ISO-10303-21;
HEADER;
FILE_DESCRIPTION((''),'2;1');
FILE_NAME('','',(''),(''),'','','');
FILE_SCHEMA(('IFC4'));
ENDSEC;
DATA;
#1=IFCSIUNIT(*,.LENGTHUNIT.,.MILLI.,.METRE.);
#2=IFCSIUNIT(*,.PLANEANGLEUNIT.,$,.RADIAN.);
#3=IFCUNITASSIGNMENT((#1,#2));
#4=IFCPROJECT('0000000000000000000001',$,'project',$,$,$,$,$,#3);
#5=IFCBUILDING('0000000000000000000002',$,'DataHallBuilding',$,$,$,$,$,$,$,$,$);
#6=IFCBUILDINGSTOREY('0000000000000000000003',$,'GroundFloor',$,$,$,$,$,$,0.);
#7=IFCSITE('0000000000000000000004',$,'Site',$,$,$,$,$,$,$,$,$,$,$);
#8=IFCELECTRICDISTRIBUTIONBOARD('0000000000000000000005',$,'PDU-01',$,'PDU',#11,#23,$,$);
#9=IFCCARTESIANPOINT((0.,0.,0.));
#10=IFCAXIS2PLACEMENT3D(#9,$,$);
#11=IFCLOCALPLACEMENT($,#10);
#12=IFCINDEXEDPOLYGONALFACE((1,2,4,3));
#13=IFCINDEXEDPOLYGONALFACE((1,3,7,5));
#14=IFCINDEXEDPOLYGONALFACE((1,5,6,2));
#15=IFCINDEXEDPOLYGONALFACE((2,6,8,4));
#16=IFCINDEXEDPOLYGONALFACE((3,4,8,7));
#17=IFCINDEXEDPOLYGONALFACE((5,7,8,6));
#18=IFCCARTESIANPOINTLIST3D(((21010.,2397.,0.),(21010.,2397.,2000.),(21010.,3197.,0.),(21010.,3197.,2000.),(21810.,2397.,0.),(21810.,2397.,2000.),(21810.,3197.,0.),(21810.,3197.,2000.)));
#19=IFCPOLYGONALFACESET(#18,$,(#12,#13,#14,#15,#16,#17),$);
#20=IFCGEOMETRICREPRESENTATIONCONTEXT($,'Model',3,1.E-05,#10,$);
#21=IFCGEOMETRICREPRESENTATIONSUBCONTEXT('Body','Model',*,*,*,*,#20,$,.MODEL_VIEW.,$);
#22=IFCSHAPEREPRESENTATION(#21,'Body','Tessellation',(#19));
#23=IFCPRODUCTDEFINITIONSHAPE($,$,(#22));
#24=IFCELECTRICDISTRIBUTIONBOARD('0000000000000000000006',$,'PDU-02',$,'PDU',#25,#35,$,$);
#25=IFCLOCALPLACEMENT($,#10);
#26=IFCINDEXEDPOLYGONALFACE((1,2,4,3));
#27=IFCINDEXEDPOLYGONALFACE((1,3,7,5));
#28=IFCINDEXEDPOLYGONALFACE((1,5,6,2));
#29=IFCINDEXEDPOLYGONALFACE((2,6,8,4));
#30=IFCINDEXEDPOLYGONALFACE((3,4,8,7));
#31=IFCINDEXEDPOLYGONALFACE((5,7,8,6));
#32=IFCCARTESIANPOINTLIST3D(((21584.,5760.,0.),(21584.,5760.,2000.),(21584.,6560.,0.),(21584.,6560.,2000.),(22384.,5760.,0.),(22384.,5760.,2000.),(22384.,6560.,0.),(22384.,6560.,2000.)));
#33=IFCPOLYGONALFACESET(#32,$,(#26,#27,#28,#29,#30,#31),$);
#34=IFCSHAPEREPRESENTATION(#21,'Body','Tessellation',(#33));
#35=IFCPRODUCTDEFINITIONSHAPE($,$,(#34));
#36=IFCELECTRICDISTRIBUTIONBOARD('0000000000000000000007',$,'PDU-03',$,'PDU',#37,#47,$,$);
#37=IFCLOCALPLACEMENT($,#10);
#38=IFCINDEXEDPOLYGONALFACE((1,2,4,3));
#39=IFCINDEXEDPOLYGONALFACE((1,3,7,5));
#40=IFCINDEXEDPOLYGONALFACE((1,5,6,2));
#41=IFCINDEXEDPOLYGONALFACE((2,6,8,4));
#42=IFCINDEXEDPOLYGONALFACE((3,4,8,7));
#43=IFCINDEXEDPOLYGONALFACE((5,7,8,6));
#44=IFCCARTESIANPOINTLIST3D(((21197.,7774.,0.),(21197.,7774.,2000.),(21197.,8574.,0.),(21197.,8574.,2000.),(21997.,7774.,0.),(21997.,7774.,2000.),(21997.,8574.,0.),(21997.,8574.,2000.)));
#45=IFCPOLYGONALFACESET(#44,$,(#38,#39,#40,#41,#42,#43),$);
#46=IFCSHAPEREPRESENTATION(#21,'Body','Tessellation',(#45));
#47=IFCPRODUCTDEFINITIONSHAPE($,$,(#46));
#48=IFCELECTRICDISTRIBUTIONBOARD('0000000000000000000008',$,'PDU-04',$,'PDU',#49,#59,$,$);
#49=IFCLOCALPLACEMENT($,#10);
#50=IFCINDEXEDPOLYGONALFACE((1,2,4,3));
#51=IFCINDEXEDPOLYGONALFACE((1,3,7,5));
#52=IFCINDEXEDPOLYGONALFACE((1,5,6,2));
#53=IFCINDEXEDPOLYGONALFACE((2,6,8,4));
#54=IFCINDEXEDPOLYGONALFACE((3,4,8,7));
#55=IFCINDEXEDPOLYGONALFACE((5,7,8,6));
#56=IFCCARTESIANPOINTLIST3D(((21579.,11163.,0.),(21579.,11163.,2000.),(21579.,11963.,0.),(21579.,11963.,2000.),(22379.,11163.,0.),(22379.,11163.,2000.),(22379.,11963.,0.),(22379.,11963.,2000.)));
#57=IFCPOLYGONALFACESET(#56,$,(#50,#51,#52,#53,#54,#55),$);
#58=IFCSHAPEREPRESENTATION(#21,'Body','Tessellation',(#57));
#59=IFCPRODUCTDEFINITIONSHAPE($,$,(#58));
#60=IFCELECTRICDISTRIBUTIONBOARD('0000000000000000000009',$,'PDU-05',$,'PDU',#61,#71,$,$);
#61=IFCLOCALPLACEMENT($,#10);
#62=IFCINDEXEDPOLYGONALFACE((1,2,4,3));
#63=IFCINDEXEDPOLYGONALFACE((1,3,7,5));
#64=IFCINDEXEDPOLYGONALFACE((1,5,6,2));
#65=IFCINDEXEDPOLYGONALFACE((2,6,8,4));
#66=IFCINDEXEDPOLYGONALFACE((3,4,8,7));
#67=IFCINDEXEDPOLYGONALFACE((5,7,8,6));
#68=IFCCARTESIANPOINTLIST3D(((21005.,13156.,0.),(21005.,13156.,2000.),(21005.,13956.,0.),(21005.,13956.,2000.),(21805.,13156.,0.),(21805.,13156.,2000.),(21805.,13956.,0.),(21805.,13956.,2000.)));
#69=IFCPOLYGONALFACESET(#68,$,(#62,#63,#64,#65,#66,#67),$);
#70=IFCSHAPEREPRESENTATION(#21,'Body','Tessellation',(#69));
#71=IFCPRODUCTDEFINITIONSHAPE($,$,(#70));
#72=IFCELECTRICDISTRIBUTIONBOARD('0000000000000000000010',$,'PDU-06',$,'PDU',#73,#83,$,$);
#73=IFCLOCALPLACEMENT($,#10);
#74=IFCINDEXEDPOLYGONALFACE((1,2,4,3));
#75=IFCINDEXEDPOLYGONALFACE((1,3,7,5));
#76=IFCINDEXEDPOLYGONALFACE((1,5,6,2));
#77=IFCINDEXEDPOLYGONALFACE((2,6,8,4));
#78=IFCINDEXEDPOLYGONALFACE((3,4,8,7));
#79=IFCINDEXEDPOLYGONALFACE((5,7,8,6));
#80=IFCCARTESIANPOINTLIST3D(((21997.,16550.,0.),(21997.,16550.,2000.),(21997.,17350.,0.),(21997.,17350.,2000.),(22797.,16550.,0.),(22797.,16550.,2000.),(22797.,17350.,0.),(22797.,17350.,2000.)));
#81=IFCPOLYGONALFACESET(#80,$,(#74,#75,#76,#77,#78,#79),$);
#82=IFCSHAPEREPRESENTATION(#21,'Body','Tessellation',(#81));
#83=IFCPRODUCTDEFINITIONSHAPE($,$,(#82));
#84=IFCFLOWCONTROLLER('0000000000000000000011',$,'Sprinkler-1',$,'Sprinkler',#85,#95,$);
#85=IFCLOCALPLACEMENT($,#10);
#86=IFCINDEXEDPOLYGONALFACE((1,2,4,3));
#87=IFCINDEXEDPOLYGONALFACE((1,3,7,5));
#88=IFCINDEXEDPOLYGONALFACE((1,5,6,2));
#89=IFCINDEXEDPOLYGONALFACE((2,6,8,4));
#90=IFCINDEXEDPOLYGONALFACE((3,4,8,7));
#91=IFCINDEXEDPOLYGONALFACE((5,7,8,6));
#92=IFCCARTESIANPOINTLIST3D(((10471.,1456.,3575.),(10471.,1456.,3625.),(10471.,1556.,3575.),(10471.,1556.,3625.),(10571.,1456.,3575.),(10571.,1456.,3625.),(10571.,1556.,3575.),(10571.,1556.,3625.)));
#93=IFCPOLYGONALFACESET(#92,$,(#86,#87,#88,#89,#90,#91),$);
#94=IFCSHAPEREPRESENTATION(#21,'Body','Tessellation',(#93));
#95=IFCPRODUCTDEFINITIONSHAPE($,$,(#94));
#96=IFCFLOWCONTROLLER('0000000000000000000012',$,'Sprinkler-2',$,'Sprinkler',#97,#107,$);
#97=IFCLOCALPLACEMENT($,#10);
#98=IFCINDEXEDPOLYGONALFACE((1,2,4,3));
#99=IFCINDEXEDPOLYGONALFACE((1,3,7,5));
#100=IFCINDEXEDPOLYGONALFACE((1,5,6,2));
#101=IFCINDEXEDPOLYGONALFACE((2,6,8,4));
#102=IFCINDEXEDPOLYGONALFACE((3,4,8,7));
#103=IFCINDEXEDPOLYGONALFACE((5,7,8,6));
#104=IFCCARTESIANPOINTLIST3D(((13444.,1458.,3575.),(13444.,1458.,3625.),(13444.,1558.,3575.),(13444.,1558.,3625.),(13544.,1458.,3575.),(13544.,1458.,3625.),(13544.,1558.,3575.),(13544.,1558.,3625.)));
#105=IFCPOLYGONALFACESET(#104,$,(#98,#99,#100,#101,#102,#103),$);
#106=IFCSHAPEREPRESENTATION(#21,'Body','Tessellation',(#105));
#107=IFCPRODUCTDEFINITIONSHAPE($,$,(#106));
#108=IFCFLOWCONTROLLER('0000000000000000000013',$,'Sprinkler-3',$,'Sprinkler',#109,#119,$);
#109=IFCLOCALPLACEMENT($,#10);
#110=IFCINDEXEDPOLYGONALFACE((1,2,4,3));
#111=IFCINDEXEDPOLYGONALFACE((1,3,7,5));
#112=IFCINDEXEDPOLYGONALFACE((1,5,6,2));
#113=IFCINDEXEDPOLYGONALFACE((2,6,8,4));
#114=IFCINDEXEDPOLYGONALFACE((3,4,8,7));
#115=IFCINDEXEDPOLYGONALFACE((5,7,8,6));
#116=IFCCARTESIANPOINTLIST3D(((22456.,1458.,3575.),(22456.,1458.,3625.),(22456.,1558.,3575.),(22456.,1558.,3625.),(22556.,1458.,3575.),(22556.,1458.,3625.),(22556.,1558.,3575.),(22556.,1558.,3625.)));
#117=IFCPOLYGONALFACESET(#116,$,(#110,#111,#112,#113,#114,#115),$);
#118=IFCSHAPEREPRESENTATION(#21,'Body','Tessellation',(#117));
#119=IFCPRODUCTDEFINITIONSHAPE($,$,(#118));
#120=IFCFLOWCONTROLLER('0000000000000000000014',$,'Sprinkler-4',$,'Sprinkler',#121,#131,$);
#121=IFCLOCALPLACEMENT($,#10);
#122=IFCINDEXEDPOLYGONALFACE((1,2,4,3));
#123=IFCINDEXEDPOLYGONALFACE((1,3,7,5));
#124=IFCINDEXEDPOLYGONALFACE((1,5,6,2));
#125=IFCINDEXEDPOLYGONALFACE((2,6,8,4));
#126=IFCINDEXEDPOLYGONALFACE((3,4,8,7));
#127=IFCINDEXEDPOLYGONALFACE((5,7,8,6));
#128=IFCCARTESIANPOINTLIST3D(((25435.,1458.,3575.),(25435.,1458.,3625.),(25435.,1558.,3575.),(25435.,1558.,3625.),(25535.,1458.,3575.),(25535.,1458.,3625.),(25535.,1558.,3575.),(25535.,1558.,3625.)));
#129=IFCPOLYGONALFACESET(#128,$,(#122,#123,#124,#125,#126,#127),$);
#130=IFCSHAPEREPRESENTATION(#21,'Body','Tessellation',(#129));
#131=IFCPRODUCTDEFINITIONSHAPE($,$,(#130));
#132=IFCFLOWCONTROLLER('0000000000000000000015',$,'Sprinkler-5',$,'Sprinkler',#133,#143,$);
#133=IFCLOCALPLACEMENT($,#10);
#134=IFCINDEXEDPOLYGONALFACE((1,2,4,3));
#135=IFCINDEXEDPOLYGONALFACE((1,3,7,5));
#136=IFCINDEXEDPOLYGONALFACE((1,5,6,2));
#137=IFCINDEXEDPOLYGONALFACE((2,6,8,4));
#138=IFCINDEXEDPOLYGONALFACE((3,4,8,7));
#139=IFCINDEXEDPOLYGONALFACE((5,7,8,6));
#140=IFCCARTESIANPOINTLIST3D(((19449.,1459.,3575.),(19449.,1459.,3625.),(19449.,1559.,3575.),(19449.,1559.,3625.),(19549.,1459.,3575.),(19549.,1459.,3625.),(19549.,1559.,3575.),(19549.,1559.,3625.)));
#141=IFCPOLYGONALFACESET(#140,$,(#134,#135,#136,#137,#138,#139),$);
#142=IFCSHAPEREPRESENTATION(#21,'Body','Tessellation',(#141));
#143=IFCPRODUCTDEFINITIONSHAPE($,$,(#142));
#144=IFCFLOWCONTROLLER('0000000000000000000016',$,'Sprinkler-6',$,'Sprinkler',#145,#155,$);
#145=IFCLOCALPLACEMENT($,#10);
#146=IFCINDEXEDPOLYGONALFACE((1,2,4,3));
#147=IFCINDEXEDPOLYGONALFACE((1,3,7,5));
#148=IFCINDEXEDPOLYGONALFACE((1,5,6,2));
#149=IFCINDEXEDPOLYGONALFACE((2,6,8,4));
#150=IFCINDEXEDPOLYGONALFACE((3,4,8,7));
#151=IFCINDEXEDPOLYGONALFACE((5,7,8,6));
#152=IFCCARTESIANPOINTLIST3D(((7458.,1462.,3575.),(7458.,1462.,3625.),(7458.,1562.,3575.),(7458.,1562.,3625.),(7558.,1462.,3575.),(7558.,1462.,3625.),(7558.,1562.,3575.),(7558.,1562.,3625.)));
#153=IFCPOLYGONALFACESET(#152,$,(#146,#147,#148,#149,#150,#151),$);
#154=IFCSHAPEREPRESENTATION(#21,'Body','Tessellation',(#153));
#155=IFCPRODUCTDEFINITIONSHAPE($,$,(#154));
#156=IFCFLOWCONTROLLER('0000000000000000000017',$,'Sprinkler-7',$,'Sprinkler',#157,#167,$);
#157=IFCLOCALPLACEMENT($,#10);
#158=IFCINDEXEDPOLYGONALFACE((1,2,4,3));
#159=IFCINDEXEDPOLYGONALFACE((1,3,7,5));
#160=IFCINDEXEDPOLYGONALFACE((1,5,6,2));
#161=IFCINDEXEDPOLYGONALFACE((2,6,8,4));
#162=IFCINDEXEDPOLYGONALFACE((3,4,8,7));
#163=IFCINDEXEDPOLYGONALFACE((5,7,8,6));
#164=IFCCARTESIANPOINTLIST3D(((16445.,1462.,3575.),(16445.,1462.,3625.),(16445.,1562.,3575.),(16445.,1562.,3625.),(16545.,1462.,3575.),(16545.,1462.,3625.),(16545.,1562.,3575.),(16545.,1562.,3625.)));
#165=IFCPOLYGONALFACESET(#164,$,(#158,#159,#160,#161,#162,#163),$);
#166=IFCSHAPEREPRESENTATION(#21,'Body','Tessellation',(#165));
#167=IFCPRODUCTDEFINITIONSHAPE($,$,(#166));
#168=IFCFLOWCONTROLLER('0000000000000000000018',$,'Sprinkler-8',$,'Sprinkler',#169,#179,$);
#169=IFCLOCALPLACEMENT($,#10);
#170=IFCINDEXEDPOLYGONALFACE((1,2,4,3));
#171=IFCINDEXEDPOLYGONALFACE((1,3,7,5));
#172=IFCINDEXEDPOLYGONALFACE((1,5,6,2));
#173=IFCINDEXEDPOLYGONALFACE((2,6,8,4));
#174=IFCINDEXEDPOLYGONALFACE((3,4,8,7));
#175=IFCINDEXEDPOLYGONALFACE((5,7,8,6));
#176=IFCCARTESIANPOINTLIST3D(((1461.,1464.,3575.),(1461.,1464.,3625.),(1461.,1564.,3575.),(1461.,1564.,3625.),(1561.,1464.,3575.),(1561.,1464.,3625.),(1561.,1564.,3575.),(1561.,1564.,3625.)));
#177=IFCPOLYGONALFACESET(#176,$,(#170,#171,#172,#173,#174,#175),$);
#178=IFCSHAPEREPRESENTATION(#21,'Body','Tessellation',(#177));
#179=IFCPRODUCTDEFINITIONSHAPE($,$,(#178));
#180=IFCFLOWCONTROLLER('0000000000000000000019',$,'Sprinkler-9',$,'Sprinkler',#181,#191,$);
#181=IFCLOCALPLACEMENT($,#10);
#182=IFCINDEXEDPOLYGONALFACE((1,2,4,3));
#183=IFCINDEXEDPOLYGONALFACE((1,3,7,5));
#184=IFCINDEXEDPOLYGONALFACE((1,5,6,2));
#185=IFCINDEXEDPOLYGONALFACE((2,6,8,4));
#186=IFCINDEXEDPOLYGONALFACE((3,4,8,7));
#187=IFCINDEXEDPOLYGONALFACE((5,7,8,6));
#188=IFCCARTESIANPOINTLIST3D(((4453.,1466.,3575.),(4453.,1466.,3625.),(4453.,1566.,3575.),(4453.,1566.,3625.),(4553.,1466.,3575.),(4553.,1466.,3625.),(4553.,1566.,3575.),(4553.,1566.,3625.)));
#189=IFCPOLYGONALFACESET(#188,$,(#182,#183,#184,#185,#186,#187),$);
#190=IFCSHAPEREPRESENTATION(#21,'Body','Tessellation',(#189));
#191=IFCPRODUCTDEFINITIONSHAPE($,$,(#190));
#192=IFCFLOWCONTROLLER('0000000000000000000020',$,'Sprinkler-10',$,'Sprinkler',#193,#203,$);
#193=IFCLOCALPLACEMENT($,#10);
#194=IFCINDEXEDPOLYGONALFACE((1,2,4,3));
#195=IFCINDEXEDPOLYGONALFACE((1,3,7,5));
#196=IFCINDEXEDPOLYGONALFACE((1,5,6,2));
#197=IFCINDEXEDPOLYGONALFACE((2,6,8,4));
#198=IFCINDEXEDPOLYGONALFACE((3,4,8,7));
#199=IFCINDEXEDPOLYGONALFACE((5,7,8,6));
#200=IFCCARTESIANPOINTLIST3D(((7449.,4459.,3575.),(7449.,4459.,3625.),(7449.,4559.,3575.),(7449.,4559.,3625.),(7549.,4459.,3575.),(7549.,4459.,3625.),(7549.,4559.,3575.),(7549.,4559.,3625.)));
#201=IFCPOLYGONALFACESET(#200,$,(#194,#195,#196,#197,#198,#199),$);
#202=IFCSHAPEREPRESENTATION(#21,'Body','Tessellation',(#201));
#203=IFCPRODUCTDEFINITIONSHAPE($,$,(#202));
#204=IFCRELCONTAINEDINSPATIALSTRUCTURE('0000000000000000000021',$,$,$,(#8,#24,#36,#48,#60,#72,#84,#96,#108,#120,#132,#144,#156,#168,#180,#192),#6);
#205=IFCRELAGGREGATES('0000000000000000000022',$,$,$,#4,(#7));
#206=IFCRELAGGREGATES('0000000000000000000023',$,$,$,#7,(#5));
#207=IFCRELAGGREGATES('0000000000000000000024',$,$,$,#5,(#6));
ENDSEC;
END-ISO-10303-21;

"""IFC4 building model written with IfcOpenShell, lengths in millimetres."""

from ifc_helpers import new_model, si_unit, frame, origin, place, context, subcontext, project, spatial, rectangle, extrude, element, save


model = new_model("IFC4")

# Units and contexts
model_context = context("Model", 3, precision=1e-05, world=origin())
body_context = subcontext(model_context, "Body", "Model", "MODEL_VIEW")
ifc_project = project(units=[si_unit("LENGTHUNIT", "METRE", prefix="MILLI"), si_unit("PLANEANGLEUNIT", "RADIAN")])

# Site, building, storey
site = spatial("IfcSite", under=ifc_project, Name="Site")
building = spatial("IfcBuilding", under=site, Name="DataHallBuilding")
storey = spatial("IfcBuildingStorey", under=building, Name="GroundFloor", Elevation=0.0)

# Electric distribution boards
electric_distribution_board_1_placement = place(None, origin())
element("IfcElectricDistributionBoard", 1, at=electric_distribution_board_1_placement, inside=storey, Name="PDU-01", ObjectType="PDU", context=body_context, shape_type="SweptSolid", body=[
    extrude(rectangle(XDim=800.0, YDim=800.0), frame((21410.0, 2797.0, 0.0), z_axis=(0.0, 0.0, 1.0), x_axis=(1.0, 0.0, 0.0)), (0.0, 0.0, 1.0), 2000.0),
])
electric_distribution_board_2_placement = place(None, origin())
element("IfcElectricDistributionBoard", 2, at=electric_distribution_board_2_placement, inside=storey, Name="PDU-02", ObjectType="PDU", context=body_context, shape_type="SweptSolid", body=[
    extrude(rectangle(XDim=800.0, YDim=800.0), frame((21984.0, 6160.0, 0.0), z_axis=(0.0, 0.0, 1.0), x_axis=(1.0, 0.0, 0.0)), (0.0, 0.0, 1.0), 2000.0),
])
electric_distribution_board_3_placement = place(None, origin())
element("IfcElectricDistributionBoard", 3, at=electric_distribution_board_3_placement, inside=storey, Name="PDU-03", ObjectType="PDU", context=body_context, shape_type="SweptSolid", body=[
    extrude(rectangle(XDim=800.0, YDim=800.0), frame((21597.0, 8174.0, 0.0), z_axis=(0.0, 0.0, 1.0), x_axis=(1.0, 0.0, 0.0)), (0.0, 0.0, 1.0), 2000.0),
])
electric_distribution_board_4_placement = place(None, origin())
element("IfcElectricDistributionBoard", 4, at=electric_distribution_board_4_placement, inside=storey, Name="PDU-04", ObjectType="PDU", context=body_context, shape_type="SweptSolid", body=[
    extrude(rectangle(XDim=800.0, YDim=800.0), frame((21979.0, 11563.0, 0.0), z_axis=(0.0, 0.0, 1.0), x_axis=(1.0, 0.0, 0.0)), (0.0, 0.0, 1.0), 2000.0),
])
electric_distribution_board_5_placement = place(None, origin())
element("IfcElectricDistributionBoard", 5, at=electric_distribution_board_5_placement, inside=storey, Name="PDU-05", ObjectType="PDU", context=body_context, shape_type="SweptSolid", body=[
    extrude(rectangle(XDim=800.0, YDim=800.0), frame((21405.0, 13556.0, 0.0), z_axis=(0.0, 0.0, 1.0), x_axis=(1.0, 0.0, 0.0)), (0.0, 0.0, 1.0), 2000.0),
])
electric_distribution_board_6_placement = place(None, origin())
element("IfcElectricDistributionBoard", 6, at=electric_distribution_board_6_placement, inside=storey, Name="PDU-06", ObjectType="PDU", context=body_context, shape_type="SweptSolid", body=[
    extrude(rectangle(XDim=800.0, YDim=800.0), frame((22397.0, 16950.0, 0.0), z_axis=(0.0, 0.0, 1.0), x_axis=(1.0, 0.0, 0.0)), (0.0, 0.0, 1.0), 2000.0),
])

# Flow controllers
flow_controller_1_placement = place(None, origin())
element("IfcFlowController", 7, at=flow_controller_1_placement, inside=storey, Name="Sprinkler-1", ObjectType="Sprinkler", context=body_context, shape_type="SweptSolid", body=[
    extrude(rectangle(XDim=100.0, YDim=100.0), frame((10521.0, 1506.0, 3575.0), z_axis=(0.0, 0.0, 1.0), x_axis=(1.0, 0.0, 0.0)), (0.0, 0.0, 1.0), 50.0),
])
flow_controller_2_placement = place(None, origin())
element("IfcFlowController", 8, at=flow_controller_2_placement, inside=storey, Name="Sprinkler-2", ObjectType="Sprinkler", context=body_context, shape_type="SweptSolid", body=[
    extrude(rectangle(XDim=100.0, YDim=100.0), frame((13494.0, 1508.0, 3575.0), z_axis=(0.0, 0.0, 1.0), x_axis=(1.0, 0.0, 0.0)), (0.0, 0.0, 1.0), 50.0),
])
flow_controller_3_placement = place(None, origin())
element("IfcFlowController", 9, at=flow_controller_3_placement, inside=storey, Name="Sprinkler-3", ObjectType="Sprinkler", context=body_context, shape_type="SweptSolid", body=[
    extrude(rectangle(XDim=100.0, YDim=100.0), frame((22506.0, 1508.0, 3575.0), z_axis=(0.0, 0.0, 1.0), x_axis=(1.0, 0.0, 0.0)), (0.0, 0.0, 1.0), 50.0),
])
flow_controller_4_placement = place(None, origin())
element("IfcFlowController", 10, at=flow_controller_4_placement, inside=storey, Name="Sprinkler-4", ObjectType="Sprinkler", context=body_context, shape_type="SweptSolid", body=[
    extrude(rectangle(XDim=100.0, YDim=100.0), frame((25485.0, 1508.0, 3575.0), z_axis=(0.0, 0.0, 1.0), x_axis=(1.0, 0.0, 0.0)), (0.0, 0.0, 1.0), 50.0),
])
flow_controller_5_placement = place(None, origin())
element("IfcFlowController", 11, at=flow_controller_5_placement, inside=storey, Name="Sprinkler-5", ObjectType="Sprinkler", context=body_context, shape_type="SweptSolid", body=[
    extrude(rectangle(XDim=100.0, YDim=100.0), frame((19499.0, 1509.0, 3575.0), z_axis=(0.0, 0.0, 1.0), x_axis=(1.0, 0.0, 0.0)), (0.0, 0.0, 1.0), 50.0),
])
flow_controller_6_placement = place(None, origin())
element("IfcFlowController", 12, at=flow_controller_6_placement, inside=storey, Name="Sprinkler-6", ObjectType="Sprinkler", context=body_context, shape_type="SweptSolid", body=[
    extrude(rectangle(XDim=100.0, YDim=100.0), frame((7508.0, 1512.0, 3575.0), z_axis=(0.0, 0.0, 1.0), x_axis=(1.0, 0.0, 0.0)), (0.0, 0.0, 1.0), 50.0),
])
flow_controller_7_placement = place(None, origin())
element("IfcFlowController", 13, at=flow_controller_7_placement, inside=storey, Name="Sprinkler-7", ObjectType="Sprinkler", context=body_context, shape_type="SweptSolid", body=[
    extrude(rectangle(XDim=100.0, YDim=100.0), frame((16495.0, 1512.0, 3575.0), z_axis=(0.0, 0.0, 1.0), x_axis=(1.0, 0.0, 0.0)), (0.0, 0.0, 1.0), 50.0),
])
flow_controller_8_placement = place(None, origin())
element("IfcFlowController", 14, at=flow_controller_8_placement, inside=storey, Name="Sprinkler-8", ObjectType="Sprinkler", context=body_context, shape_type="SweptSolid", body=[
    extrude(rectangle(XDim=100.0, YDim=100.0), frame((1511.0, 1514.0, 3575.0), z_axis=(0.0, 0.0, 1.0), x_axis=(1.0, 0.0, 0.0)), (0.0, 0.0, 1.0), 50.0),
])
flow_controller_9_placement = place(None, origin())
element("IfcFlowController", 15, at=flow_controller_9_placement, inside=storey, Name="Sprinkler-9", ObjectType="Sprinkler", context=body_context, shape_type="SweptSolid", body=[
    extrude(rectangle(XDim=100.0, YDim=100.0), frame((4503.0, 1516.0, 3575.0), z_axis=(0.0, 0.0, 1.0), x_axis=(1.0, 0.0, 0.0)), (0.0, 0.0, 1.0), 50.0),
])
flow_controller_10_placement = place(None, origin())
element("IfcFlowController", 16, at=flow_controller_10_placement, inside=storey, Name="Sprinkler-10", ObjectType="Sprinkler", context=body_context, shape_type="SweptSolid", body=[
    extrude(rectangle(XDim=100.0, YDim=100.0), frame((7499.0, 4509.0, 3575.0), z_axis=(0.0, 0.0, 1.0), x_axis=(1.0, 0.0, 0.0)), (0.0, 0.0, 1.0), 50.0),
])

save(model, "model.ifc")
